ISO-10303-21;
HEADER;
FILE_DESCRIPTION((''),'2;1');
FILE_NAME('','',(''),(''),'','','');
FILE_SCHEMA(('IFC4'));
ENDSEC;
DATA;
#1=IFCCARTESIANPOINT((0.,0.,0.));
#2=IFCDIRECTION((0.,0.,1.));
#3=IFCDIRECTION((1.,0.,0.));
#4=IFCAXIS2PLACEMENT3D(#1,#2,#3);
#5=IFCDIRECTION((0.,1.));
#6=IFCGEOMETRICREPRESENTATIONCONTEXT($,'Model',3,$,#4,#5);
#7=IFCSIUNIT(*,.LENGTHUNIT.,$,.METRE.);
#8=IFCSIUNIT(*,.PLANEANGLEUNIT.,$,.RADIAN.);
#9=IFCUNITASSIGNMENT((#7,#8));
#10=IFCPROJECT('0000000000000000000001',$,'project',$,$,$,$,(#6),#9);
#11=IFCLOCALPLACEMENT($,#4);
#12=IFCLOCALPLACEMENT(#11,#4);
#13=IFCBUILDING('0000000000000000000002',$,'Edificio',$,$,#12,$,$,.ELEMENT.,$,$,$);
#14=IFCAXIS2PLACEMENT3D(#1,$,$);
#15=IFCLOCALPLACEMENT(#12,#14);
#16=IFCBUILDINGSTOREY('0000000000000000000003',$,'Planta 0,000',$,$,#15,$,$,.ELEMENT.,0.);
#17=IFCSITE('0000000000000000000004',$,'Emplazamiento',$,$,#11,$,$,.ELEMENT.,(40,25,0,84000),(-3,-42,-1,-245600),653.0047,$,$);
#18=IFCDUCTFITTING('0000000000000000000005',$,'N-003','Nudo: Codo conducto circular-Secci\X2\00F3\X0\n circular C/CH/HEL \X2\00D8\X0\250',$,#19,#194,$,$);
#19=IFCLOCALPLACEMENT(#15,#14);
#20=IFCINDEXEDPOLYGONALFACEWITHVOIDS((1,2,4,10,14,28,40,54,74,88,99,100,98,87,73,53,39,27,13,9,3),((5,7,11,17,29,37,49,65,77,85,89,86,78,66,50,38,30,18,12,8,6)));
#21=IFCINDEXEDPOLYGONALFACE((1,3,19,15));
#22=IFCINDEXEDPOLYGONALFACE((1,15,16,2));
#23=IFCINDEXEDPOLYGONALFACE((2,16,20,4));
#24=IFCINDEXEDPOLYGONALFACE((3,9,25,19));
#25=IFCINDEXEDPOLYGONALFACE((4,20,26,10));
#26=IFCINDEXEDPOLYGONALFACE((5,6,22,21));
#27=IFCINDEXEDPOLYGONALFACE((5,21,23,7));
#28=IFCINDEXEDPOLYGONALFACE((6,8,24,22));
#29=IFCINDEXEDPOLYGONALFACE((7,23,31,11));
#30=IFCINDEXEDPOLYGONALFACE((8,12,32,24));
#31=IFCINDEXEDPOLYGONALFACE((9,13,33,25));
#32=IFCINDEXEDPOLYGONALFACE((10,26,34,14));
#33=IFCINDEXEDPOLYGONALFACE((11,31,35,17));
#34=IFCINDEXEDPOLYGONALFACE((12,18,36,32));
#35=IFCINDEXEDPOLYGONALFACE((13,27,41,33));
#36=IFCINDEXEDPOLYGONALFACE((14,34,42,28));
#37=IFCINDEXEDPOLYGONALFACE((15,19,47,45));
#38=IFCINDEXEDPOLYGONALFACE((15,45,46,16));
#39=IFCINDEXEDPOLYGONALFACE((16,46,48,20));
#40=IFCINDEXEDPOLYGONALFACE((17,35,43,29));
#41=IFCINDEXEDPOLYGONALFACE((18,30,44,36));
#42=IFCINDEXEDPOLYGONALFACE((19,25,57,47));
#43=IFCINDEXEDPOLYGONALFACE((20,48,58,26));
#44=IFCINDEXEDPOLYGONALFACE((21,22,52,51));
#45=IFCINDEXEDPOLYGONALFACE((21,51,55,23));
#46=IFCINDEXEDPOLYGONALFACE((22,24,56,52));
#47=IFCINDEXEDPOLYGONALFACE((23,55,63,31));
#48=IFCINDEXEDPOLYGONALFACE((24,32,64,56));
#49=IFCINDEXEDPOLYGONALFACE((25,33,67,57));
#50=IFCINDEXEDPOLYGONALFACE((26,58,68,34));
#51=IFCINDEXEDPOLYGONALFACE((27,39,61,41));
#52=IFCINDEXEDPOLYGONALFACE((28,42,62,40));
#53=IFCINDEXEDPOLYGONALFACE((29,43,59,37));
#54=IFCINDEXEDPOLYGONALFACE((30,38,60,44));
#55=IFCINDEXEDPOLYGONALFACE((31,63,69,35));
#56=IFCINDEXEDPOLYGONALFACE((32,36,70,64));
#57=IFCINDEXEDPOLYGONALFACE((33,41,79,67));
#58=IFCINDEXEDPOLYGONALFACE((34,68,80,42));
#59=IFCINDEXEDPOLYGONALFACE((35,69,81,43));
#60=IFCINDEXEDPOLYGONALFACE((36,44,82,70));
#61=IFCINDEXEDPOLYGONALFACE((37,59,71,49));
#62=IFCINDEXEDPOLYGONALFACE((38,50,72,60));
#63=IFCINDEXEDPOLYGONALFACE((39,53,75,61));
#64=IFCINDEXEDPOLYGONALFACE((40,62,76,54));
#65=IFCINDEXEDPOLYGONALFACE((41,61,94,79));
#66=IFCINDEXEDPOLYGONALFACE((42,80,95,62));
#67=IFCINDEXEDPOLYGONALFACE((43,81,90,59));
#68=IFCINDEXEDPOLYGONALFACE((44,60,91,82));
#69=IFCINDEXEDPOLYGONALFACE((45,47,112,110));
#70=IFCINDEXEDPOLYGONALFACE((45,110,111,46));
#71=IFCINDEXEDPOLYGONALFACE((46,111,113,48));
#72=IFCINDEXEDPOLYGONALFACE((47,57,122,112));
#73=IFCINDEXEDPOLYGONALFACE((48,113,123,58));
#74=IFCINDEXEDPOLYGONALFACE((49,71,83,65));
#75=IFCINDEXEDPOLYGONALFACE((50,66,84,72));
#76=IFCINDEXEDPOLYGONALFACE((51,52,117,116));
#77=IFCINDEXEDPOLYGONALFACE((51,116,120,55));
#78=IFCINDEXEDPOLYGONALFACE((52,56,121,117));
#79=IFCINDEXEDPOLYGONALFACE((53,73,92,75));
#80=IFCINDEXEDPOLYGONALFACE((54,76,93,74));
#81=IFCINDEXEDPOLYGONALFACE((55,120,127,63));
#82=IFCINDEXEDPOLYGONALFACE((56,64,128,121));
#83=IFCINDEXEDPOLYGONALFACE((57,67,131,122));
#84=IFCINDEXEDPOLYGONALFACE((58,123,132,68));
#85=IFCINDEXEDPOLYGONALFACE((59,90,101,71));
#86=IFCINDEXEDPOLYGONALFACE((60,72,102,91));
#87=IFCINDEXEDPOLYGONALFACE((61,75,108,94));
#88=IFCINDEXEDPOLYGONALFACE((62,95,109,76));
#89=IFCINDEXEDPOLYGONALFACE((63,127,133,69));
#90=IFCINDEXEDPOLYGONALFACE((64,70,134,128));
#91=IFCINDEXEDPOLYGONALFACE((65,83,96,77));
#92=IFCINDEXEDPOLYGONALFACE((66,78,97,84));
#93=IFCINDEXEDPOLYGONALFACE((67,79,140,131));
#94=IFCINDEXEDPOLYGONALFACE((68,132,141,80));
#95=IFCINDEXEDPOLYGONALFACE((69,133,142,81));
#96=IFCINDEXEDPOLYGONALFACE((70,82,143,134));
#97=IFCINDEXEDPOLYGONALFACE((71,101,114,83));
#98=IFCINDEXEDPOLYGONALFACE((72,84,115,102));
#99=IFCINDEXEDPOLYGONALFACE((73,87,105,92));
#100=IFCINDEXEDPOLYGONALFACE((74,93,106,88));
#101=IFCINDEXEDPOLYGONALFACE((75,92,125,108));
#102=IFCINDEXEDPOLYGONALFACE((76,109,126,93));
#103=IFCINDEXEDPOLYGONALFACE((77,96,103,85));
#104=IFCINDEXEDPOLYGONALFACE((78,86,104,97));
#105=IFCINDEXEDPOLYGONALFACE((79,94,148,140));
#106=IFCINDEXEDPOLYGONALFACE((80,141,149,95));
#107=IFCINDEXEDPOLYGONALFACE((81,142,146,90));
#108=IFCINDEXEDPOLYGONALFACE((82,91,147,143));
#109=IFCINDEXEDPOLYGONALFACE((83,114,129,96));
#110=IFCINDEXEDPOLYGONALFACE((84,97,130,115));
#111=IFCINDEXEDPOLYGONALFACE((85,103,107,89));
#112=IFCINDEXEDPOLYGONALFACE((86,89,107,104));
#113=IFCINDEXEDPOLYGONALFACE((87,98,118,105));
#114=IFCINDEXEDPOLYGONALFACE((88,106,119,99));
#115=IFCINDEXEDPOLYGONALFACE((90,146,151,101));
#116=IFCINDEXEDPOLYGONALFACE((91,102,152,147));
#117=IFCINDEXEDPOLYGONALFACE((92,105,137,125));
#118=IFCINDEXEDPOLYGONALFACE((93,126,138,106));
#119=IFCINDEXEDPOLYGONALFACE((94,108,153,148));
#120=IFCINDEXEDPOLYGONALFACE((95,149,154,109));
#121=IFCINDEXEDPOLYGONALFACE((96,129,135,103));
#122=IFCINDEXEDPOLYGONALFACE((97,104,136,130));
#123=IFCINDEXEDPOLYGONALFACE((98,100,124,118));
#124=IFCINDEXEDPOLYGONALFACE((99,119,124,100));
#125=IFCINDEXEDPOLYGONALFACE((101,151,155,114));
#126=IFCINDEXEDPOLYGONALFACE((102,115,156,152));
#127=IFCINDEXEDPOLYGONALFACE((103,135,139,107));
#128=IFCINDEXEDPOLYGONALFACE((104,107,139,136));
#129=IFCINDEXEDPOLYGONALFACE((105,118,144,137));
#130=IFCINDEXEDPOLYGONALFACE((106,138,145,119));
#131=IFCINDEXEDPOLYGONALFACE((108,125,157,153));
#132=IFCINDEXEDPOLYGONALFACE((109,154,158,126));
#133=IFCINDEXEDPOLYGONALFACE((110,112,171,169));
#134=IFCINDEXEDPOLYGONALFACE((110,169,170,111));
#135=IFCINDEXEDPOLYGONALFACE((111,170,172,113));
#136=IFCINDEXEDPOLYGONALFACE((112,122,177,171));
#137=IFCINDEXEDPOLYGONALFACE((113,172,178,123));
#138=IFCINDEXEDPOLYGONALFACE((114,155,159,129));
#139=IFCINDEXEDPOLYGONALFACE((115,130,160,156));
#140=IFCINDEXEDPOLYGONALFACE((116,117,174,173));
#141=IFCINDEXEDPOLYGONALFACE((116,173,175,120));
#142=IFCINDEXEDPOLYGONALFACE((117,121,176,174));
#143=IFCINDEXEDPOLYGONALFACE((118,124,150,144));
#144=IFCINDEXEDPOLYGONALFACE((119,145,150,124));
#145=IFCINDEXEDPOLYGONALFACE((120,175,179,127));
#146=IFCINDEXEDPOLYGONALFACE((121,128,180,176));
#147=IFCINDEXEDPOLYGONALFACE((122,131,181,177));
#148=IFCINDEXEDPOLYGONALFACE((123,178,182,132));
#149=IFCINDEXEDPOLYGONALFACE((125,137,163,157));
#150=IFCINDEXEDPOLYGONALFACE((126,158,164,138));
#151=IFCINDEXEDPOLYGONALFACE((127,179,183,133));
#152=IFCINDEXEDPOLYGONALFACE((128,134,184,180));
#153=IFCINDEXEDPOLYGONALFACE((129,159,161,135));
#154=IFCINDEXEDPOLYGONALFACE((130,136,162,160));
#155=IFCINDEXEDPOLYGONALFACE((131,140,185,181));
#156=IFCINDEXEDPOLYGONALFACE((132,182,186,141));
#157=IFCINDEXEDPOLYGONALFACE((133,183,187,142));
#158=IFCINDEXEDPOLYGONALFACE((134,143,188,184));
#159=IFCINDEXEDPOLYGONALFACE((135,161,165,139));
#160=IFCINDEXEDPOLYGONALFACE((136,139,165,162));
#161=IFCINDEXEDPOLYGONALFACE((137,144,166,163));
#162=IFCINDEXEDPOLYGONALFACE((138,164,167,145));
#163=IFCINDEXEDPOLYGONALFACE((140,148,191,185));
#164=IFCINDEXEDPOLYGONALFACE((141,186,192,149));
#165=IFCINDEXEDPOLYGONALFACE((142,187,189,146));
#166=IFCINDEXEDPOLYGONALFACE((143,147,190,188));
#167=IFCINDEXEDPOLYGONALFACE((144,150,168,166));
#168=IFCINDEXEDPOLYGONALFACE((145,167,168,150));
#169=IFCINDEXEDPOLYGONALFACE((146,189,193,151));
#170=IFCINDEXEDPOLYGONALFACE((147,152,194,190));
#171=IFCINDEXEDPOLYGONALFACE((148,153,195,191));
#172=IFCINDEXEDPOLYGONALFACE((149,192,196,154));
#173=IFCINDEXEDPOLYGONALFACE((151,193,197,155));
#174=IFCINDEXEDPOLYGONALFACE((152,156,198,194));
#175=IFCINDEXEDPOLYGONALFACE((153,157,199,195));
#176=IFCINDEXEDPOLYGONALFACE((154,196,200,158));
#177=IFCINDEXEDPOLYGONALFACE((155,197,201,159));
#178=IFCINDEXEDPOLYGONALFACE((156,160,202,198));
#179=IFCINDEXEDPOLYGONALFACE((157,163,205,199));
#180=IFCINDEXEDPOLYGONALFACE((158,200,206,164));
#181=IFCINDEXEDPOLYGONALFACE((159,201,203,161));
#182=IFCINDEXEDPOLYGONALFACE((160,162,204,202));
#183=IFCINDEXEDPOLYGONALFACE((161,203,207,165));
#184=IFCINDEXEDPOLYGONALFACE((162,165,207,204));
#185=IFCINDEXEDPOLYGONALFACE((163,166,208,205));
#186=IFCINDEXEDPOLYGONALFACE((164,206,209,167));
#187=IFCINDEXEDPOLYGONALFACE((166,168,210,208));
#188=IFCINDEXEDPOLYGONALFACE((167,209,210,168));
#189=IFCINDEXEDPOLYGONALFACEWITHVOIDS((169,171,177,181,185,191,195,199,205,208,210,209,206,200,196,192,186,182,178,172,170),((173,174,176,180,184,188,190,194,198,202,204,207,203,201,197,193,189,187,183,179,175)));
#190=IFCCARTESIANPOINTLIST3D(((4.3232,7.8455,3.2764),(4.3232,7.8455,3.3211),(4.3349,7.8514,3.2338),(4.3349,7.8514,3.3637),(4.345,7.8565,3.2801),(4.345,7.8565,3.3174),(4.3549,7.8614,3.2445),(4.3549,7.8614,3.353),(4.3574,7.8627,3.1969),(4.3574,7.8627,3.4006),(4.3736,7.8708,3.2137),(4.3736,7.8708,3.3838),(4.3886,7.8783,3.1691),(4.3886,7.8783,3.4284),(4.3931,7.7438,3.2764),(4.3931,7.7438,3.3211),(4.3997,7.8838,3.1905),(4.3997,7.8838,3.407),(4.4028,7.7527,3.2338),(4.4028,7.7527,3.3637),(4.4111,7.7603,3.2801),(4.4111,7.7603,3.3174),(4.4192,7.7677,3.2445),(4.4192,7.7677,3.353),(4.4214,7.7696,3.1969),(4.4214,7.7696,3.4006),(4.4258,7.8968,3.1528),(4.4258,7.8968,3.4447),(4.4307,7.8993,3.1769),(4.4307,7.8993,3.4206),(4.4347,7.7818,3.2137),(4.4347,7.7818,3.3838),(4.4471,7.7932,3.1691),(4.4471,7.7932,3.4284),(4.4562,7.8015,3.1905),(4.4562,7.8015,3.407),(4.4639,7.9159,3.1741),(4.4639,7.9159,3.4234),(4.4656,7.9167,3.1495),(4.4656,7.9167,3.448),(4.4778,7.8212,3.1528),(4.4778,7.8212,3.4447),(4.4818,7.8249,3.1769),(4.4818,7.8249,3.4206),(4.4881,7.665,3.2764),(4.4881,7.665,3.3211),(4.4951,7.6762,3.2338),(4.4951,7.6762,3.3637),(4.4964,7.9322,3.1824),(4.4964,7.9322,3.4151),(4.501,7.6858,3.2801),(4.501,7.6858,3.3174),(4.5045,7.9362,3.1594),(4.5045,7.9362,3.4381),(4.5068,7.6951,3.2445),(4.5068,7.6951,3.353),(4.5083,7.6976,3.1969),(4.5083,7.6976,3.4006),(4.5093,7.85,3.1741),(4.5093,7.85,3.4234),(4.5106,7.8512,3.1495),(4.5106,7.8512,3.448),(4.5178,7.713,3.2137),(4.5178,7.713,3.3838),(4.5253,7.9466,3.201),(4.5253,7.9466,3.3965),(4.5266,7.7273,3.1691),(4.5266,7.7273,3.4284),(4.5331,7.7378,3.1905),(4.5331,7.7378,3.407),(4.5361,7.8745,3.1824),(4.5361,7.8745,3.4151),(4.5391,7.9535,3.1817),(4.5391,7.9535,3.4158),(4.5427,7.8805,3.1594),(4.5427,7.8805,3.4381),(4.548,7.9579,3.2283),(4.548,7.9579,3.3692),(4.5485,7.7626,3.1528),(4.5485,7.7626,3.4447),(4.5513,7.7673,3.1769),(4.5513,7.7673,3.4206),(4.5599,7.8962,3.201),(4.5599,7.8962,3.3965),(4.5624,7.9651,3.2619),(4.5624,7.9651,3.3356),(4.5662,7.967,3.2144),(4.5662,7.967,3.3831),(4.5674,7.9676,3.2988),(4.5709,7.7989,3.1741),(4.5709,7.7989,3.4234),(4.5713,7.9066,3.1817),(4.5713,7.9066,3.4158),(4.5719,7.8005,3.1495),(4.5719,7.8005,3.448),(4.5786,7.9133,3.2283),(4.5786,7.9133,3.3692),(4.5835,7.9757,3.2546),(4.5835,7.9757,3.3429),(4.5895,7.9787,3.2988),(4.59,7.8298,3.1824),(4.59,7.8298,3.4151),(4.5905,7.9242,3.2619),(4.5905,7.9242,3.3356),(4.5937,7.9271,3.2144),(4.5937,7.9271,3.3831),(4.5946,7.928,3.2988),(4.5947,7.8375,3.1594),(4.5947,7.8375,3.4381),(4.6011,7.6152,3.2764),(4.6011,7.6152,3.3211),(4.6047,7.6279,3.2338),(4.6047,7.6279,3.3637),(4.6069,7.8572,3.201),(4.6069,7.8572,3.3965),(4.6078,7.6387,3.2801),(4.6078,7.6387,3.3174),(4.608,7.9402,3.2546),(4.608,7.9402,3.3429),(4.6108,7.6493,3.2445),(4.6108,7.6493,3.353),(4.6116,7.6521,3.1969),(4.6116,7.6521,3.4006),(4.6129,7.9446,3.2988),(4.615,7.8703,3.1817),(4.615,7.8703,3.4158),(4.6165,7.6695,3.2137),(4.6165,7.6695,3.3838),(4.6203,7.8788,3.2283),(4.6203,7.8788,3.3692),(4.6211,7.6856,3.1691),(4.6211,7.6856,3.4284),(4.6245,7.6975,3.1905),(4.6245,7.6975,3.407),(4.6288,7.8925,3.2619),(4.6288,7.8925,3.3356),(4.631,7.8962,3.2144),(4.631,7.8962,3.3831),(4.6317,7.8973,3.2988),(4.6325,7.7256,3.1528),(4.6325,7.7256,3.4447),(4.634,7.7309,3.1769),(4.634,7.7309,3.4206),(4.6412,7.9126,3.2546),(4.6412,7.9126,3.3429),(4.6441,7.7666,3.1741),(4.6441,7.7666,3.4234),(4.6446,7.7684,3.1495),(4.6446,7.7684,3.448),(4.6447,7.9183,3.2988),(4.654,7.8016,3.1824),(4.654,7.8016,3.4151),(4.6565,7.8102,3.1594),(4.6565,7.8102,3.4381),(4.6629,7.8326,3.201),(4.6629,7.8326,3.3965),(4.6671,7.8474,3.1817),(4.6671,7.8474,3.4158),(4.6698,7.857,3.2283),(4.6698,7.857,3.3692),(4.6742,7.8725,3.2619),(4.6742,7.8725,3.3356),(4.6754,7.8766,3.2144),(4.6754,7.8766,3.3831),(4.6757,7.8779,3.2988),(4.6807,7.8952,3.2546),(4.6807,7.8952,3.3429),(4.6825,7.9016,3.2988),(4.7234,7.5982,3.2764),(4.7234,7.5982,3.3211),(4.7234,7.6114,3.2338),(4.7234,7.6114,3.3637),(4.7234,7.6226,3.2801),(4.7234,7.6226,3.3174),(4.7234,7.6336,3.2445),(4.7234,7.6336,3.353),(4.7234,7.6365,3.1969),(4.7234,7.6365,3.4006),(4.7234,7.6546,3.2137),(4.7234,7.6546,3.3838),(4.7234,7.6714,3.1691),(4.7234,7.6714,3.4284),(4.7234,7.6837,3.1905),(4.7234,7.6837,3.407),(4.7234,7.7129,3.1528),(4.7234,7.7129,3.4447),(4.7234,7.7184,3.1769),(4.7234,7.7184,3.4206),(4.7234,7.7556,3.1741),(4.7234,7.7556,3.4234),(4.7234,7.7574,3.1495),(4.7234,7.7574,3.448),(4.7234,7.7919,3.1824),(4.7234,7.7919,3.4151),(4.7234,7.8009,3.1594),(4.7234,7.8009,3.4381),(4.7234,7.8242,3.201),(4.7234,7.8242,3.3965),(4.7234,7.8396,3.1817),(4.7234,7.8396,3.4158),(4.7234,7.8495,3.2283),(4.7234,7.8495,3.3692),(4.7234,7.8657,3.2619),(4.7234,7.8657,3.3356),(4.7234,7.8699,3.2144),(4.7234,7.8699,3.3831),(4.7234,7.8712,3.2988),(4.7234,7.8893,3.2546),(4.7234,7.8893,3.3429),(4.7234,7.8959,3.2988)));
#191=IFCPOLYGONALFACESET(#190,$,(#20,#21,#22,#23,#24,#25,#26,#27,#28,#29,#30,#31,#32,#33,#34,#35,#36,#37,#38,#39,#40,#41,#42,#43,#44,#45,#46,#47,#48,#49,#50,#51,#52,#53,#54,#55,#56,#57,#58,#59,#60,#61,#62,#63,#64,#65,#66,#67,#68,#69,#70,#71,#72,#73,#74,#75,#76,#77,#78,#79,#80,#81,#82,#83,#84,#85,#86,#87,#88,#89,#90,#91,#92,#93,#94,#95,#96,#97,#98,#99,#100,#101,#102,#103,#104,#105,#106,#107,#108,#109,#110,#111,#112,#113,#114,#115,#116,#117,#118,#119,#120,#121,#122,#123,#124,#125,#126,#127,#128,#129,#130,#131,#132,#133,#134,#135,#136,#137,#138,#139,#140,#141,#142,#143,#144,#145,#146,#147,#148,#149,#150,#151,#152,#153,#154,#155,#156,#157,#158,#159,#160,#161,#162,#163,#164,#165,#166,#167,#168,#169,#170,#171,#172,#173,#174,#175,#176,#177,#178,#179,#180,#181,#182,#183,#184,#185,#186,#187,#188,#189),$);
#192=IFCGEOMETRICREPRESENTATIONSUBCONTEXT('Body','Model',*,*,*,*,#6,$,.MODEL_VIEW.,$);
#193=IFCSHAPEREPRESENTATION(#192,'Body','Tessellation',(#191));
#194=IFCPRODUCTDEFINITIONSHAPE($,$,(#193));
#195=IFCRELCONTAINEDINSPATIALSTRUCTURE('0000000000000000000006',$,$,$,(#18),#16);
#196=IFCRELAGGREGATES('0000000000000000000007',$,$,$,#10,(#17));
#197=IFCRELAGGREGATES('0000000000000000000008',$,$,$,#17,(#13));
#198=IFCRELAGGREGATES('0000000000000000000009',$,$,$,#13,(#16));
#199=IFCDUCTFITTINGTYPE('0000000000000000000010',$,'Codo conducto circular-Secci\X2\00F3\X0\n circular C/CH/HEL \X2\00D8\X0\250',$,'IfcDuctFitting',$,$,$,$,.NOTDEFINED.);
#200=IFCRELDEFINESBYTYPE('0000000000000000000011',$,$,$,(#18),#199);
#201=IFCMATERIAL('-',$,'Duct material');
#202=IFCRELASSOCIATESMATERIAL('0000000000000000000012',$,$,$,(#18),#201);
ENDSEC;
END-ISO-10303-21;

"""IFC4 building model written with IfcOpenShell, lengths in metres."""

from ifc_helpers import new_model, entity, si_unit, direction, origin, origin_with_axes, place, context, subcontext, project, spatial, source, transform, mapped, material, type_object, element, save


model = new_model("IFC4")

# Units and contexts
model_context = context("Model", 3, world=origin_with_axes(), true_north=direction((0.0, 1.0)))
body_context = subcontext(model_context, "Body", "Model", "MODEL_VIEW")
ifc_project = project(units=[si_unit("LENGTHUNIT", "METRE"), si_unit("PLANEANGLEUNIT", "RADIAN")], contexts=[model_context])

# Site, building, storey
site_placement = place(None, origin_with_axes())
site = spatial("IfcSite", under=ifc_project, at=site_placement, Name="Emplazamiento", CompositionType="ELEMENT", RefLatitude=(40, 25, 0, 84000), RefLongitude=(-3, -42, -1, -245600), RefElevation=653.0047)
building_placement = place(site_placement, origin_with_axes())
building = spatial("IfcBuilding", under=site, at=building_placement, Name="Edificio", CompositionType="ELEMENT")
storey_placement = place(building_placement, origin())
storey = spatial("IfcBuildingStorey", under=building, at=storey_placement, Name="Planta 0,000", CompositionType="ELEMENT", Elevation=0.0)

# Shared definitions
ifc_material_1 = material(Name="-", Category="Duct material")

# Duct fitting
duct_fitting_type_1 = type_object("IfcDuctFittingType", Name="Codo conducto circular-Sección circular C/CH/HEL Ø250", ApplicableOccurrence="IfcDuctFitting", PredefinedType="NOTDEFINED")
shared_shape_1 = source(origin_with_axes(), body_context, "Body", "SweptSolid", [
    entity("IfcRevolvedAreaSolid", entity("IfcCircleHollowProfileDef", "AREA", None, entity("IfcAxis2Placement2D", entity("IfcCartesianPoint", [0.0, 0.0]), entity("IfcDirection", [1.0, 0.0])), 0.1497, 0.0247), entity("IfcAxis2Placement3D", entity("IfcCartesianPoint", [0.1655, 0.0828, 0.0]), entity("IfcDirection", [-0.894427, -0.447214, 0.0]), entity("IfcDirection", [0.447214, -0.894427, 0.0])), entity("IfcAxis1Placement", entity("IfcCartesianPoint", [0.2994, 0.0, 0.0]), entity("IfcDirection", [0.0, 1.0, 0.0])), 1.107149),
])
duct_fitting_1_placement = place(storey_placement, origin_with_axes())
element("IfcDuctFitting", 1, at=duct_fitting_1_placement, inside=storey, type_object=duct_fitting_type_1, material=ifc_material_1, Name="N-003", Description="Nudo: Codo conducto circular-Sección circular C/CH/HEL Ø250", context=body_context, shape_type="MappedRepresentation", body=[
    mapped(shared_shape_1, transform((4.5383, 7.7462, 3.2988), x_axis=(0.894427, 0.447214, 0.0), y_axis=(0.447214, -0.894427, 0.0), z_axis=(0.0, 0.0, -1.0), scale=1.0)),
])

save(model, "model.ifc")
